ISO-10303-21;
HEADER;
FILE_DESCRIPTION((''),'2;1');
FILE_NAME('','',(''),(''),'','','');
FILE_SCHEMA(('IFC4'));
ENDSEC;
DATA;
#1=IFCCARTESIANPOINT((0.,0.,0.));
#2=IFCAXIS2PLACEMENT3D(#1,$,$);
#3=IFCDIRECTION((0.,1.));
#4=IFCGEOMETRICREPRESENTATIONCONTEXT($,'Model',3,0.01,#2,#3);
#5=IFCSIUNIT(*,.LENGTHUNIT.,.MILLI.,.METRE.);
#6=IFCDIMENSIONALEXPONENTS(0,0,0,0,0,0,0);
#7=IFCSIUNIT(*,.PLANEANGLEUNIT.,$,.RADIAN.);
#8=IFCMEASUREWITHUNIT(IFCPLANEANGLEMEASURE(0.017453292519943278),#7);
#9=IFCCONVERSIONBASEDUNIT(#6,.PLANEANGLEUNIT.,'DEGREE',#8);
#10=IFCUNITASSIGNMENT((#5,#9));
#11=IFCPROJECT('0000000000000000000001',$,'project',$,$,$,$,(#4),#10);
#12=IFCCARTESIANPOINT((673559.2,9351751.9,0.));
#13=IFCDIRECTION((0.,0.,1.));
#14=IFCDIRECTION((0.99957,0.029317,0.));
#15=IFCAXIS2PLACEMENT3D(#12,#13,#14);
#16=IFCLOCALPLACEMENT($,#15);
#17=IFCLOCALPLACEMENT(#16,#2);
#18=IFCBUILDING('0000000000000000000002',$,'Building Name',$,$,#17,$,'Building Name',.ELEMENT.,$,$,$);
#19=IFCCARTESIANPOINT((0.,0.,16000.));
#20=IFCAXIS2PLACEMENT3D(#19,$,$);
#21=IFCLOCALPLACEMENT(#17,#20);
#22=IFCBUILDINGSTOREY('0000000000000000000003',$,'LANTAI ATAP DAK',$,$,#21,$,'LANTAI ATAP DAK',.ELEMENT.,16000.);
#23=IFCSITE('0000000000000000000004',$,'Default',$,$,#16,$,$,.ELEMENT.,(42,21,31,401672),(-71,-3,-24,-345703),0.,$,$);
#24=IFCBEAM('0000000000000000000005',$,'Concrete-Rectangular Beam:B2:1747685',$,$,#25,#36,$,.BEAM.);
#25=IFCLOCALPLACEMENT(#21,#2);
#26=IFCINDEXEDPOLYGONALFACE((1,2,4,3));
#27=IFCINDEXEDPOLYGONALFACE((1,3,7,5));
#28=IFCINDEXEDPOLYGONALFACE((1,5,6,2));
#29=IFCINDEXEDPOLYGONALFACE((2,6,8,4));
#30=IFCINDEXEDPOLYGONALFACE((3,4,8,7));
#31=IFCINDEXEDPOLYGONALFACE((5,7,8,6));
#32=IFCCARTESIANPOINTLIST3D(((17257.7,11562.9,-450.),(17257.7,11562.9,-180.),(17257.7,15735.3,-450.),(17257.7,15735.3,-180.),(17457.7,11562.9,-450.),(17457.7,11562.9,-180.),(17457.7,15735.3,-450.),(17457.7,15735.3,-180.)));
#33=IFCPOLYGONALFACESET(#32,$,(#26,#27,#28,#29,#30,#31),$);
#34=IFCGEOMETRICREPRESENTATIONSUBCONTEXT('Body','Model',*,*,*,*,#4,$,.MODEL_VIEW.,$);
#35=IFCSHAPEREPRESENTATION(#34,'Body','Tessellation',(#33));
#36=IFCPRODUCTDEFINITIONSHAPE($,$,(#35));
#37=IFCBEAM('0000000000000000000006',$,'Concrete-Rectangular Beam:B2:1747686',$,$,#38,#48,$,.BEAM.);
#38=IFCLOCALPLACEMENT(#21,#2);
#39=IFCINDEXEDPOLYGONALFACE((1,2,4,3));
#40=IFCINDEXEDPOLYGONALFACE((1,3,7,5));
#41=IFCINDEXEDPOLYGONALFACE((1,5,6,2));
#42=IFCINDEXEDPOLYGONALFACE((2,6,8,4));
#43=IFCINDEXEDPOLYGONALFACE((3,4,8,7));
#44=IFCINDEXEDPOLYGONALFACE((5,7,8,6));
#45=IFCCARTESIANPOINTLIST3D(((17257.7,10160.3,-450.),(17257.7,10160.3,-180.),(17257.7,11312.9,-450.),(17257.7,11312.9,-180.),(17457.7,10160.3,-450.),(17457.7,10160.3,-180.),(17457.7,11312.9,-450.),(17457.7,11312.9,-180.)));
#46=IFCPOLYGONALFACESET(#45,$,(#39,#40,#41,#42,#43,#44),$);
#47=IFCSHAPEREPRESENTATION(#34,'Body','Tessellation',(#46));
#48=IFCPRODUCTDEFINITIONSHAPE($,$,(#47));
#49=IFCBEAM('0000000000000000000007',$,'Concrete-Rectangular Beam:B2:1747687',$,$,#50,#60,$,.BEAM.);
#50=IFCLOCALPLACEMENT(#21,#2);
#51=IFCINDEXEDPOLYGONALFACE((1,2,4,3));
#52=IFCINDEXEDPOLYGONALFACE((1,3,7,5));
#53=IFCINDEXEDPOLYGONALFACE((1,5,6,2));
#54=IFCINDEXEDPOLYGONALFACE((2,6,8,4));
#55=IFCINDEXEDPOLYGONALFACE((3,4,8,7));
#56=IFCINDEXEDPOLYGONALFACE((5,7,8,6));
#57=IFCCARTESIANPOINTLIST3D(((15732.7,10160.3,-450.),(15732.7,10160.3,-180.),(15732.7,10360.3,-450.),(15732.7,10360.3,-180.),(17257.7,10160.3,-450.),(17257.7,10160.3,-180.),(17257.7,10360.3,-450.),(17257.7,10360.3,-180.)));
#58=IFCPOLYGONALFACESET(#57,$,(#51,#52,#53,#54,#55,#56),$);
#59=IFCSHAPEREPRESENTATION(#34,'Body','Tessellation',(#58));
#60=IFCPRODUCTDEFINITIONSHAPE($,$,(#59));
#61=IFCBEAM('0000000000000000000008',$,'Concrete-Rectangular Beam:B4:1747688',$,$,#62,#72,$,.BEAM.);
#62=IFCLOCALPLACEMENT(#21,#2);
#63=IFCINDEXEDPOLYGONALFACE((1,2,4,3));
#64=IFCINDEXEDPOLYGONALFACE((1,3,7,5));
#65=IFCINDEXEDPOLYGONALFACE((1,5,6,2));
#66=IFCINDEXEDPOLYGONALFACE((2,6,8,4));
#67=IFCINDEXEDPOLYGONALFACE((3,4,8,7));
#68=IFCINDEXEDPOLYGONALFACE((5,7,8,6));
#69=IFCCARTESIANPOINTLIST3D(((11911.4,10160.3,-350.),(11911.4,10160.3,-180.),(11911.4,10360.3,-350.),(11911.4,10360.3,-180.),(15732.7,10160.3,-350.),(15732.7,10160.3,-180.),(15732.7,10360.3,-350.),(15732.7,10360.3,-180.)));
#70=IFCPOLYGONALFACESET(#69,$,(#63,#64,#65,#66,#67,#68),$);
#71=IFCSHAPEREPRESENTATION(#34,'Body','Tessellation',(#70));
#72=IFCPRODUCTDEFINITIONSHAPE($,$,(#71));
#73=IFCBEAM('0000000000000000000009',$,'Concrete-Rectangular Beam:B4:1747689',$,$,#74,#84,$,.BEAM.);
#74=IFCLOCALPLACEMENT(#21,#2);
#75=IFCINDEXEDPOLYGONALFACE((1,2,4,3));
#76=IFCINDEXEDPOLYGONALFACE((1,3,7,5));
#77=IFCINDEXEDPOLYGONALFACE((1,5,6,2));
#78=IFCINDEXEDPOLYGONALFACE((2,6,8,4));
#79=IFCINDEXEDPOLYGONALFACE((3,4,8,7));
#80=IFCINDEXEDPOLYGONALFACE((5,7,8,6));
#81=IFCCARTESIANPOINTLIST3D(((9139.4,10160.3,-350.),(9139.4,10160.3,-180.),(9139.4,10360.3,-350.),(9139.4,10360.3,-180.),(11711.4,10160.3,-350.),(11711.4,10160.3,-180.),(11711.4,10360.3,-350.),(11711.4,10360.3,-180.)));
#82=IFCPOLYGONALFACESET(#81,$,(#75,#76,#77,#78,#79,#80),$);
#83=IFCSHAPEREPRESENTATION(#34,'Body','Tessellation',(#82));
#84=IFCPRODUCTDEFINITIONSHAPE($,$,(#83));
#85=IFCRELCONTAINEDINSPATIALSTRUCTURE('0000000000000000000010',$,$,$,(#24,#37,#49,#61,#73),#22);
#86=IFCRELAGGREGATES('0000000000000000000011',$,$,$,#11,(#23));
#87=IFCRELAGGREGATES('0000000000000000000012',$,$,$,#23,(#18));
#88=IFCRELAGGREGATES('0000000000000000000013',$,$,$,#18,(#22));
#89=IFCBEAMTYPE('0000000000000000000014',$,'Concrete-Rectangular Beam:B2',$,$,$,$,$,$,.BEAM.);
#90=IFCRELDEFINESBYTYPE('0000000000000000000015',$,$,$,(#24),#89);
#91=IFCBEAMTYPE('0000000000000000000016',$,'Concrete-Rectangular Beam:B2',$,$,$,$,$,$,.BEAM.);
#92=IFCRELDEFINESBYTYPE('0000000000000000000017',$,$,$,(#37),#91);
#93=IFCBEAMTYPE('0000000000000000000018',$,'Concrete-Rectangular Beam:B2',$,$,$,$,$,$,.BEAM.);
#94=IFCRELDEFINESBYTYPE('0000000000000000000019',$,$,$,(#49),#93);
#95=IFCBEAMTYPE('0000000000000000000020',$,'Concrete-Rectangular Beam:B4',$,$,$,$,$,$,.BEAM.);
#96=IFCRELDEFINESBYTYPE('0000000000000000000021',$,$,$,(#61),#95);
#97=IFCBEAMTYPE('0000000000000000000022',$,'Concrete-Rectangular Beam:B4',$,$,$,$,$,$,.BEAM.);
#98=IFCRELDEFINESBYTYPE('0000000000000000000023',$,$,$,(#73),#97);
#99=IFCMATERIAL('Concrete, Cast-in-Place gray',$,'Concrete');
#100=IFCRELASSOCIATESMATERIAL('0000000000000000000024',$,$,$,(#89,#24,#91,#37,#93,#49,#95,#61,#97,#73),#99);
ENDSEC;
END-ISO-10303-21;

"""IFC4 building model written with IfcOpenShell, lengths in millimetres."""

from ifc_helpers import new_model, entity, si_unit, converted_unit, direction, frame, origin, place, context, subcontext, project, spatial, indexed_curve, outline, extrude, source, transform, mapped, material, type_object, type_shapes, element, save


model = new_model("IFC4")

# Units and contexts
model_context = context("Model", 3, precision=0.01, world=origin(), true_north=direction((0.0, 1.0)))
body_context = subcontext(model_context, "Body", "Model", "MODEL_VIEW")
ifc_project = project(units=[si_unit("LENGTHUNIT", "METRE", prefix="MILLI"), converted_unit("PLANEANGLEUNIT", "DEGREE", entity("IfcPlaneAngleMeasure", 0.017453292519943278), si_unit("PLANEANGLEUNIT", "RADIAN"), dimensions=[0, 0, 0, 0, 0, 0, 0])], contexts=[model_context])

# Site, building, storey
site_placement = place(None, frame((673559.2, 9351751.9, 0.0), z_axis=(0.0, 0.0, 1.0), x_axis=(0.99957, 0.029317, 0.0)))
site = spatial("IfcSite", under=ifc_project, at=site_placement, Name="Default", CompositionType="ELEMENT", RefLatitude=(42, 21, 31, 401672), RefLongitude=(-71, -3, -24, -345703), RefElevation=0.0)
building_placement = place(site_placement, origin())
building = spatial("IfcBuilding", under=site, at=building_placement, Name="Building Name", LongName="Building Name", CompositionType="ELEMENT")
storey_placement = place(building_placement, frame((0.0, 0.0, 16000.0)))
storey = spatial("IfcBuildingStorey", under=building, at=storey_placement, Name="LANTAI ATAP DAK", LongName="LANTAI ATAP DAK", CompositionType="ELEMENT", Elevation=16000.0)

# Shared definitions
ifc_material = material(Name="Concrete, Cast-in-Place gray", Category="Concrete")

# Beams
beam_type_1 = type_object("IfcBeamType", Name="Concrete-Rectangular Beam:B2", PredefinedType="BEAM", material=ifc_material)
shared_shape_1 = source(origin(), body_context, "Body", "SweptSolid", [
    extrude(outline(indexed_curve([(-100.0, -135.0), (100.0, -135.0), (100.0, 135.0), (-100.0, 135.0), (-100.0, -135.0)], self_intersect=False)), frame((17357.7, 15735.3, 15685.0), z_axis=(0.0, -1.0, 0.0), x_axis=(-1.0, 0.0, 0.0)), (0.0, 0.0, 1.0), 4172.4),
])
type_shapes(beam_type_1, [shared_shape_1])
beam_1_placement = place(storey_placement, frame((0.0, 0.0, -16000.0)))
element("IfcBeam", 1, at=beam_1_placement, inside=storey, type_object=beam_type_1, material=ifc_material, Name="Concrete-Rectangular Beam:B2:1747685", PredefinedType="BEAM", context=body_context, shape_type="MappedRepresentation", body=[
    mapped(shared_shape_1, transform((0.0, 0.0, 0.0), scale=1.0)),
])
beam_type_2 = type_object("IfcBeamType", Name="Concrete-Rectangular Beam:B2", PredefinedType="BEAM", material=ifc_material)
shared_shape_2 = source(origin(), body_context, "Body", "SweptSolid", [
    extrude(outline(indexed_curve([(-100.0, -135.0), (100.0, -135.0), (100.0, 135.0), (-100.0, 135.0), (-100.0, -135.0)], self_intersect=False)), frame((17357.7, 11312.9, 15685.0), z_axis=(0.0, -1.0, 0.0), x_axis=(-1.0, 0.0, 0.0)), (0.0, 0.0, 1.0), 1152.6),
])
type_shapes(beam_type_2, [shared_shape_2])
beam_2_placement = place(storey_placement, frame((0.0, 0.0, -16000.0)))
element("IfcBeam", 2, at=beam_2_placement, inside=storey, type_object=beam_type_2, material=ifc_material, Name="Concrete-Rectangular Beam:B2:1747686", PredefinedType="BEAM", context=body_context, shape_type="MappedRepresentation", body=[
    mapped(shared_shape_2, transform((0.0, 0.0, 0.0), scale=1.0)),
])
beam_type_3 = type_object("IfcBeamType", Name="Concrete-Rectangular Beam:B2", PredefinedType="BEAM", material=ifc_material)
shared_shape_3 = source(origin(), body_context, "Body", "SweptSolid", [
    extrude(outline(indexed_curve([(-135.0, -100.0), (135.0, -100.0), (135.0, 100.0), (-135.0, 100.0), (-135.0, -100.0)], self_intersect=False)), frame((17257.7, 10260.3, 15685.0), z_axis=(-1.0, 0.0, 0.0), x_axis=(0.0, 0.0, -1.0)), (0.0, 0.0, 1.0), 1525.0),
])
type_shapes(beam_type_3, [shared_shape_3])
beam_3_placement = place(storey_placement, frame((0.0, 0.0, -16000.0)))
element("IfcBeam", 3, at=beam_3_placement, inside=storey, type_object=beam_type_3, material=ifc_material, Name="Concrete-Rectangular Beam:B2:1747687", PredefinedType="BEAM", context=body_context, shape_type="MappedRepresentation", body=[
    mapped(shared_shape_3, transform((0.0, 0.0, 0.0), scale=1.0)),
])
beam_type_4 = type_object("IfcBeamType", Name="Concrete-Rectangular Beam:B4", PredefinedType="BEAM", material=ifc_material)
shared_shape_4 = source(origin(), body_context, "Body", "SweptSolid", [
    extrude(outline(indexed_curve([(-85.0, -100.0), (85.0, -100.0), (85.0, 100.0), (-85.0, 100.0), (-85.0, -100.0)], self_intersect=False)), frame((15732.7, 10260.3, 15735.0), z_axis=(-1.0, 0.0, 0.0), x_axis=(0.0, 0.0, -1.0)), (0.0, 0.0, 1.0), 3821.2),
])
type_shapes(beam_type_4, [shared_shape_4])
beam_4_placement = place(storey_placement, frame((0.0, 0.0, -16000.0)))
element("IfcBeam", 4, at=beam_4_placement, inside=storey, type_object=beam_type_4, material=ifc_material, Name="Concrete-Rectangular Beam:B4:1747688", PredefinedType="BEAM", context=body_context, shape_type="MappedRepresentation", body=[
    mapped(shared_shape_4, transform((0.0, 0.0, 0.0), scale=1.0)),
])
beam_type_5 = type_object("IfcBeamType", Name="Concrete-Rectangular Beam:B4", PredefinedType="BEAM", material=ifc_material)
shared_shape_5 = source(origin(), body_context, "Body", "SweptSolid", [
    extrude(outline(indexed_curve([(-85.0, -100.0), (85.0, -100.0), (85.0, 100.0), (-85.0, 100.0), (-85.0, -100.0)], self_intersect=False)), frame((11711.4, 10260.3, 15735.0), z_axis=(-1.0, 0.0, 0.0), x_axis=(0.0, 0.0, -1.0)), (0.0, 0.0, 1.0), 2572.1),
])
type_shapes(beam_type_5, [shared_shape_5])
beam_5_placement = place(storey_placement, frame((0.0, 0.0, -16000.0)))
element("IfcBeam", 5, at=beam_5_placement, inside=storey, type_object=beam_type_5, material=ifc_material, Name="Concrete-Rectangular Beam:B4:1747689", PredefinedType="BEAM", context=body_context, shape_type="MappedRepresentation", body=[
    mapped(shared_shape_5, transform((0.0, 0.0, 0.0), scale=1.0)),
])

save(model, "model.ifc")
